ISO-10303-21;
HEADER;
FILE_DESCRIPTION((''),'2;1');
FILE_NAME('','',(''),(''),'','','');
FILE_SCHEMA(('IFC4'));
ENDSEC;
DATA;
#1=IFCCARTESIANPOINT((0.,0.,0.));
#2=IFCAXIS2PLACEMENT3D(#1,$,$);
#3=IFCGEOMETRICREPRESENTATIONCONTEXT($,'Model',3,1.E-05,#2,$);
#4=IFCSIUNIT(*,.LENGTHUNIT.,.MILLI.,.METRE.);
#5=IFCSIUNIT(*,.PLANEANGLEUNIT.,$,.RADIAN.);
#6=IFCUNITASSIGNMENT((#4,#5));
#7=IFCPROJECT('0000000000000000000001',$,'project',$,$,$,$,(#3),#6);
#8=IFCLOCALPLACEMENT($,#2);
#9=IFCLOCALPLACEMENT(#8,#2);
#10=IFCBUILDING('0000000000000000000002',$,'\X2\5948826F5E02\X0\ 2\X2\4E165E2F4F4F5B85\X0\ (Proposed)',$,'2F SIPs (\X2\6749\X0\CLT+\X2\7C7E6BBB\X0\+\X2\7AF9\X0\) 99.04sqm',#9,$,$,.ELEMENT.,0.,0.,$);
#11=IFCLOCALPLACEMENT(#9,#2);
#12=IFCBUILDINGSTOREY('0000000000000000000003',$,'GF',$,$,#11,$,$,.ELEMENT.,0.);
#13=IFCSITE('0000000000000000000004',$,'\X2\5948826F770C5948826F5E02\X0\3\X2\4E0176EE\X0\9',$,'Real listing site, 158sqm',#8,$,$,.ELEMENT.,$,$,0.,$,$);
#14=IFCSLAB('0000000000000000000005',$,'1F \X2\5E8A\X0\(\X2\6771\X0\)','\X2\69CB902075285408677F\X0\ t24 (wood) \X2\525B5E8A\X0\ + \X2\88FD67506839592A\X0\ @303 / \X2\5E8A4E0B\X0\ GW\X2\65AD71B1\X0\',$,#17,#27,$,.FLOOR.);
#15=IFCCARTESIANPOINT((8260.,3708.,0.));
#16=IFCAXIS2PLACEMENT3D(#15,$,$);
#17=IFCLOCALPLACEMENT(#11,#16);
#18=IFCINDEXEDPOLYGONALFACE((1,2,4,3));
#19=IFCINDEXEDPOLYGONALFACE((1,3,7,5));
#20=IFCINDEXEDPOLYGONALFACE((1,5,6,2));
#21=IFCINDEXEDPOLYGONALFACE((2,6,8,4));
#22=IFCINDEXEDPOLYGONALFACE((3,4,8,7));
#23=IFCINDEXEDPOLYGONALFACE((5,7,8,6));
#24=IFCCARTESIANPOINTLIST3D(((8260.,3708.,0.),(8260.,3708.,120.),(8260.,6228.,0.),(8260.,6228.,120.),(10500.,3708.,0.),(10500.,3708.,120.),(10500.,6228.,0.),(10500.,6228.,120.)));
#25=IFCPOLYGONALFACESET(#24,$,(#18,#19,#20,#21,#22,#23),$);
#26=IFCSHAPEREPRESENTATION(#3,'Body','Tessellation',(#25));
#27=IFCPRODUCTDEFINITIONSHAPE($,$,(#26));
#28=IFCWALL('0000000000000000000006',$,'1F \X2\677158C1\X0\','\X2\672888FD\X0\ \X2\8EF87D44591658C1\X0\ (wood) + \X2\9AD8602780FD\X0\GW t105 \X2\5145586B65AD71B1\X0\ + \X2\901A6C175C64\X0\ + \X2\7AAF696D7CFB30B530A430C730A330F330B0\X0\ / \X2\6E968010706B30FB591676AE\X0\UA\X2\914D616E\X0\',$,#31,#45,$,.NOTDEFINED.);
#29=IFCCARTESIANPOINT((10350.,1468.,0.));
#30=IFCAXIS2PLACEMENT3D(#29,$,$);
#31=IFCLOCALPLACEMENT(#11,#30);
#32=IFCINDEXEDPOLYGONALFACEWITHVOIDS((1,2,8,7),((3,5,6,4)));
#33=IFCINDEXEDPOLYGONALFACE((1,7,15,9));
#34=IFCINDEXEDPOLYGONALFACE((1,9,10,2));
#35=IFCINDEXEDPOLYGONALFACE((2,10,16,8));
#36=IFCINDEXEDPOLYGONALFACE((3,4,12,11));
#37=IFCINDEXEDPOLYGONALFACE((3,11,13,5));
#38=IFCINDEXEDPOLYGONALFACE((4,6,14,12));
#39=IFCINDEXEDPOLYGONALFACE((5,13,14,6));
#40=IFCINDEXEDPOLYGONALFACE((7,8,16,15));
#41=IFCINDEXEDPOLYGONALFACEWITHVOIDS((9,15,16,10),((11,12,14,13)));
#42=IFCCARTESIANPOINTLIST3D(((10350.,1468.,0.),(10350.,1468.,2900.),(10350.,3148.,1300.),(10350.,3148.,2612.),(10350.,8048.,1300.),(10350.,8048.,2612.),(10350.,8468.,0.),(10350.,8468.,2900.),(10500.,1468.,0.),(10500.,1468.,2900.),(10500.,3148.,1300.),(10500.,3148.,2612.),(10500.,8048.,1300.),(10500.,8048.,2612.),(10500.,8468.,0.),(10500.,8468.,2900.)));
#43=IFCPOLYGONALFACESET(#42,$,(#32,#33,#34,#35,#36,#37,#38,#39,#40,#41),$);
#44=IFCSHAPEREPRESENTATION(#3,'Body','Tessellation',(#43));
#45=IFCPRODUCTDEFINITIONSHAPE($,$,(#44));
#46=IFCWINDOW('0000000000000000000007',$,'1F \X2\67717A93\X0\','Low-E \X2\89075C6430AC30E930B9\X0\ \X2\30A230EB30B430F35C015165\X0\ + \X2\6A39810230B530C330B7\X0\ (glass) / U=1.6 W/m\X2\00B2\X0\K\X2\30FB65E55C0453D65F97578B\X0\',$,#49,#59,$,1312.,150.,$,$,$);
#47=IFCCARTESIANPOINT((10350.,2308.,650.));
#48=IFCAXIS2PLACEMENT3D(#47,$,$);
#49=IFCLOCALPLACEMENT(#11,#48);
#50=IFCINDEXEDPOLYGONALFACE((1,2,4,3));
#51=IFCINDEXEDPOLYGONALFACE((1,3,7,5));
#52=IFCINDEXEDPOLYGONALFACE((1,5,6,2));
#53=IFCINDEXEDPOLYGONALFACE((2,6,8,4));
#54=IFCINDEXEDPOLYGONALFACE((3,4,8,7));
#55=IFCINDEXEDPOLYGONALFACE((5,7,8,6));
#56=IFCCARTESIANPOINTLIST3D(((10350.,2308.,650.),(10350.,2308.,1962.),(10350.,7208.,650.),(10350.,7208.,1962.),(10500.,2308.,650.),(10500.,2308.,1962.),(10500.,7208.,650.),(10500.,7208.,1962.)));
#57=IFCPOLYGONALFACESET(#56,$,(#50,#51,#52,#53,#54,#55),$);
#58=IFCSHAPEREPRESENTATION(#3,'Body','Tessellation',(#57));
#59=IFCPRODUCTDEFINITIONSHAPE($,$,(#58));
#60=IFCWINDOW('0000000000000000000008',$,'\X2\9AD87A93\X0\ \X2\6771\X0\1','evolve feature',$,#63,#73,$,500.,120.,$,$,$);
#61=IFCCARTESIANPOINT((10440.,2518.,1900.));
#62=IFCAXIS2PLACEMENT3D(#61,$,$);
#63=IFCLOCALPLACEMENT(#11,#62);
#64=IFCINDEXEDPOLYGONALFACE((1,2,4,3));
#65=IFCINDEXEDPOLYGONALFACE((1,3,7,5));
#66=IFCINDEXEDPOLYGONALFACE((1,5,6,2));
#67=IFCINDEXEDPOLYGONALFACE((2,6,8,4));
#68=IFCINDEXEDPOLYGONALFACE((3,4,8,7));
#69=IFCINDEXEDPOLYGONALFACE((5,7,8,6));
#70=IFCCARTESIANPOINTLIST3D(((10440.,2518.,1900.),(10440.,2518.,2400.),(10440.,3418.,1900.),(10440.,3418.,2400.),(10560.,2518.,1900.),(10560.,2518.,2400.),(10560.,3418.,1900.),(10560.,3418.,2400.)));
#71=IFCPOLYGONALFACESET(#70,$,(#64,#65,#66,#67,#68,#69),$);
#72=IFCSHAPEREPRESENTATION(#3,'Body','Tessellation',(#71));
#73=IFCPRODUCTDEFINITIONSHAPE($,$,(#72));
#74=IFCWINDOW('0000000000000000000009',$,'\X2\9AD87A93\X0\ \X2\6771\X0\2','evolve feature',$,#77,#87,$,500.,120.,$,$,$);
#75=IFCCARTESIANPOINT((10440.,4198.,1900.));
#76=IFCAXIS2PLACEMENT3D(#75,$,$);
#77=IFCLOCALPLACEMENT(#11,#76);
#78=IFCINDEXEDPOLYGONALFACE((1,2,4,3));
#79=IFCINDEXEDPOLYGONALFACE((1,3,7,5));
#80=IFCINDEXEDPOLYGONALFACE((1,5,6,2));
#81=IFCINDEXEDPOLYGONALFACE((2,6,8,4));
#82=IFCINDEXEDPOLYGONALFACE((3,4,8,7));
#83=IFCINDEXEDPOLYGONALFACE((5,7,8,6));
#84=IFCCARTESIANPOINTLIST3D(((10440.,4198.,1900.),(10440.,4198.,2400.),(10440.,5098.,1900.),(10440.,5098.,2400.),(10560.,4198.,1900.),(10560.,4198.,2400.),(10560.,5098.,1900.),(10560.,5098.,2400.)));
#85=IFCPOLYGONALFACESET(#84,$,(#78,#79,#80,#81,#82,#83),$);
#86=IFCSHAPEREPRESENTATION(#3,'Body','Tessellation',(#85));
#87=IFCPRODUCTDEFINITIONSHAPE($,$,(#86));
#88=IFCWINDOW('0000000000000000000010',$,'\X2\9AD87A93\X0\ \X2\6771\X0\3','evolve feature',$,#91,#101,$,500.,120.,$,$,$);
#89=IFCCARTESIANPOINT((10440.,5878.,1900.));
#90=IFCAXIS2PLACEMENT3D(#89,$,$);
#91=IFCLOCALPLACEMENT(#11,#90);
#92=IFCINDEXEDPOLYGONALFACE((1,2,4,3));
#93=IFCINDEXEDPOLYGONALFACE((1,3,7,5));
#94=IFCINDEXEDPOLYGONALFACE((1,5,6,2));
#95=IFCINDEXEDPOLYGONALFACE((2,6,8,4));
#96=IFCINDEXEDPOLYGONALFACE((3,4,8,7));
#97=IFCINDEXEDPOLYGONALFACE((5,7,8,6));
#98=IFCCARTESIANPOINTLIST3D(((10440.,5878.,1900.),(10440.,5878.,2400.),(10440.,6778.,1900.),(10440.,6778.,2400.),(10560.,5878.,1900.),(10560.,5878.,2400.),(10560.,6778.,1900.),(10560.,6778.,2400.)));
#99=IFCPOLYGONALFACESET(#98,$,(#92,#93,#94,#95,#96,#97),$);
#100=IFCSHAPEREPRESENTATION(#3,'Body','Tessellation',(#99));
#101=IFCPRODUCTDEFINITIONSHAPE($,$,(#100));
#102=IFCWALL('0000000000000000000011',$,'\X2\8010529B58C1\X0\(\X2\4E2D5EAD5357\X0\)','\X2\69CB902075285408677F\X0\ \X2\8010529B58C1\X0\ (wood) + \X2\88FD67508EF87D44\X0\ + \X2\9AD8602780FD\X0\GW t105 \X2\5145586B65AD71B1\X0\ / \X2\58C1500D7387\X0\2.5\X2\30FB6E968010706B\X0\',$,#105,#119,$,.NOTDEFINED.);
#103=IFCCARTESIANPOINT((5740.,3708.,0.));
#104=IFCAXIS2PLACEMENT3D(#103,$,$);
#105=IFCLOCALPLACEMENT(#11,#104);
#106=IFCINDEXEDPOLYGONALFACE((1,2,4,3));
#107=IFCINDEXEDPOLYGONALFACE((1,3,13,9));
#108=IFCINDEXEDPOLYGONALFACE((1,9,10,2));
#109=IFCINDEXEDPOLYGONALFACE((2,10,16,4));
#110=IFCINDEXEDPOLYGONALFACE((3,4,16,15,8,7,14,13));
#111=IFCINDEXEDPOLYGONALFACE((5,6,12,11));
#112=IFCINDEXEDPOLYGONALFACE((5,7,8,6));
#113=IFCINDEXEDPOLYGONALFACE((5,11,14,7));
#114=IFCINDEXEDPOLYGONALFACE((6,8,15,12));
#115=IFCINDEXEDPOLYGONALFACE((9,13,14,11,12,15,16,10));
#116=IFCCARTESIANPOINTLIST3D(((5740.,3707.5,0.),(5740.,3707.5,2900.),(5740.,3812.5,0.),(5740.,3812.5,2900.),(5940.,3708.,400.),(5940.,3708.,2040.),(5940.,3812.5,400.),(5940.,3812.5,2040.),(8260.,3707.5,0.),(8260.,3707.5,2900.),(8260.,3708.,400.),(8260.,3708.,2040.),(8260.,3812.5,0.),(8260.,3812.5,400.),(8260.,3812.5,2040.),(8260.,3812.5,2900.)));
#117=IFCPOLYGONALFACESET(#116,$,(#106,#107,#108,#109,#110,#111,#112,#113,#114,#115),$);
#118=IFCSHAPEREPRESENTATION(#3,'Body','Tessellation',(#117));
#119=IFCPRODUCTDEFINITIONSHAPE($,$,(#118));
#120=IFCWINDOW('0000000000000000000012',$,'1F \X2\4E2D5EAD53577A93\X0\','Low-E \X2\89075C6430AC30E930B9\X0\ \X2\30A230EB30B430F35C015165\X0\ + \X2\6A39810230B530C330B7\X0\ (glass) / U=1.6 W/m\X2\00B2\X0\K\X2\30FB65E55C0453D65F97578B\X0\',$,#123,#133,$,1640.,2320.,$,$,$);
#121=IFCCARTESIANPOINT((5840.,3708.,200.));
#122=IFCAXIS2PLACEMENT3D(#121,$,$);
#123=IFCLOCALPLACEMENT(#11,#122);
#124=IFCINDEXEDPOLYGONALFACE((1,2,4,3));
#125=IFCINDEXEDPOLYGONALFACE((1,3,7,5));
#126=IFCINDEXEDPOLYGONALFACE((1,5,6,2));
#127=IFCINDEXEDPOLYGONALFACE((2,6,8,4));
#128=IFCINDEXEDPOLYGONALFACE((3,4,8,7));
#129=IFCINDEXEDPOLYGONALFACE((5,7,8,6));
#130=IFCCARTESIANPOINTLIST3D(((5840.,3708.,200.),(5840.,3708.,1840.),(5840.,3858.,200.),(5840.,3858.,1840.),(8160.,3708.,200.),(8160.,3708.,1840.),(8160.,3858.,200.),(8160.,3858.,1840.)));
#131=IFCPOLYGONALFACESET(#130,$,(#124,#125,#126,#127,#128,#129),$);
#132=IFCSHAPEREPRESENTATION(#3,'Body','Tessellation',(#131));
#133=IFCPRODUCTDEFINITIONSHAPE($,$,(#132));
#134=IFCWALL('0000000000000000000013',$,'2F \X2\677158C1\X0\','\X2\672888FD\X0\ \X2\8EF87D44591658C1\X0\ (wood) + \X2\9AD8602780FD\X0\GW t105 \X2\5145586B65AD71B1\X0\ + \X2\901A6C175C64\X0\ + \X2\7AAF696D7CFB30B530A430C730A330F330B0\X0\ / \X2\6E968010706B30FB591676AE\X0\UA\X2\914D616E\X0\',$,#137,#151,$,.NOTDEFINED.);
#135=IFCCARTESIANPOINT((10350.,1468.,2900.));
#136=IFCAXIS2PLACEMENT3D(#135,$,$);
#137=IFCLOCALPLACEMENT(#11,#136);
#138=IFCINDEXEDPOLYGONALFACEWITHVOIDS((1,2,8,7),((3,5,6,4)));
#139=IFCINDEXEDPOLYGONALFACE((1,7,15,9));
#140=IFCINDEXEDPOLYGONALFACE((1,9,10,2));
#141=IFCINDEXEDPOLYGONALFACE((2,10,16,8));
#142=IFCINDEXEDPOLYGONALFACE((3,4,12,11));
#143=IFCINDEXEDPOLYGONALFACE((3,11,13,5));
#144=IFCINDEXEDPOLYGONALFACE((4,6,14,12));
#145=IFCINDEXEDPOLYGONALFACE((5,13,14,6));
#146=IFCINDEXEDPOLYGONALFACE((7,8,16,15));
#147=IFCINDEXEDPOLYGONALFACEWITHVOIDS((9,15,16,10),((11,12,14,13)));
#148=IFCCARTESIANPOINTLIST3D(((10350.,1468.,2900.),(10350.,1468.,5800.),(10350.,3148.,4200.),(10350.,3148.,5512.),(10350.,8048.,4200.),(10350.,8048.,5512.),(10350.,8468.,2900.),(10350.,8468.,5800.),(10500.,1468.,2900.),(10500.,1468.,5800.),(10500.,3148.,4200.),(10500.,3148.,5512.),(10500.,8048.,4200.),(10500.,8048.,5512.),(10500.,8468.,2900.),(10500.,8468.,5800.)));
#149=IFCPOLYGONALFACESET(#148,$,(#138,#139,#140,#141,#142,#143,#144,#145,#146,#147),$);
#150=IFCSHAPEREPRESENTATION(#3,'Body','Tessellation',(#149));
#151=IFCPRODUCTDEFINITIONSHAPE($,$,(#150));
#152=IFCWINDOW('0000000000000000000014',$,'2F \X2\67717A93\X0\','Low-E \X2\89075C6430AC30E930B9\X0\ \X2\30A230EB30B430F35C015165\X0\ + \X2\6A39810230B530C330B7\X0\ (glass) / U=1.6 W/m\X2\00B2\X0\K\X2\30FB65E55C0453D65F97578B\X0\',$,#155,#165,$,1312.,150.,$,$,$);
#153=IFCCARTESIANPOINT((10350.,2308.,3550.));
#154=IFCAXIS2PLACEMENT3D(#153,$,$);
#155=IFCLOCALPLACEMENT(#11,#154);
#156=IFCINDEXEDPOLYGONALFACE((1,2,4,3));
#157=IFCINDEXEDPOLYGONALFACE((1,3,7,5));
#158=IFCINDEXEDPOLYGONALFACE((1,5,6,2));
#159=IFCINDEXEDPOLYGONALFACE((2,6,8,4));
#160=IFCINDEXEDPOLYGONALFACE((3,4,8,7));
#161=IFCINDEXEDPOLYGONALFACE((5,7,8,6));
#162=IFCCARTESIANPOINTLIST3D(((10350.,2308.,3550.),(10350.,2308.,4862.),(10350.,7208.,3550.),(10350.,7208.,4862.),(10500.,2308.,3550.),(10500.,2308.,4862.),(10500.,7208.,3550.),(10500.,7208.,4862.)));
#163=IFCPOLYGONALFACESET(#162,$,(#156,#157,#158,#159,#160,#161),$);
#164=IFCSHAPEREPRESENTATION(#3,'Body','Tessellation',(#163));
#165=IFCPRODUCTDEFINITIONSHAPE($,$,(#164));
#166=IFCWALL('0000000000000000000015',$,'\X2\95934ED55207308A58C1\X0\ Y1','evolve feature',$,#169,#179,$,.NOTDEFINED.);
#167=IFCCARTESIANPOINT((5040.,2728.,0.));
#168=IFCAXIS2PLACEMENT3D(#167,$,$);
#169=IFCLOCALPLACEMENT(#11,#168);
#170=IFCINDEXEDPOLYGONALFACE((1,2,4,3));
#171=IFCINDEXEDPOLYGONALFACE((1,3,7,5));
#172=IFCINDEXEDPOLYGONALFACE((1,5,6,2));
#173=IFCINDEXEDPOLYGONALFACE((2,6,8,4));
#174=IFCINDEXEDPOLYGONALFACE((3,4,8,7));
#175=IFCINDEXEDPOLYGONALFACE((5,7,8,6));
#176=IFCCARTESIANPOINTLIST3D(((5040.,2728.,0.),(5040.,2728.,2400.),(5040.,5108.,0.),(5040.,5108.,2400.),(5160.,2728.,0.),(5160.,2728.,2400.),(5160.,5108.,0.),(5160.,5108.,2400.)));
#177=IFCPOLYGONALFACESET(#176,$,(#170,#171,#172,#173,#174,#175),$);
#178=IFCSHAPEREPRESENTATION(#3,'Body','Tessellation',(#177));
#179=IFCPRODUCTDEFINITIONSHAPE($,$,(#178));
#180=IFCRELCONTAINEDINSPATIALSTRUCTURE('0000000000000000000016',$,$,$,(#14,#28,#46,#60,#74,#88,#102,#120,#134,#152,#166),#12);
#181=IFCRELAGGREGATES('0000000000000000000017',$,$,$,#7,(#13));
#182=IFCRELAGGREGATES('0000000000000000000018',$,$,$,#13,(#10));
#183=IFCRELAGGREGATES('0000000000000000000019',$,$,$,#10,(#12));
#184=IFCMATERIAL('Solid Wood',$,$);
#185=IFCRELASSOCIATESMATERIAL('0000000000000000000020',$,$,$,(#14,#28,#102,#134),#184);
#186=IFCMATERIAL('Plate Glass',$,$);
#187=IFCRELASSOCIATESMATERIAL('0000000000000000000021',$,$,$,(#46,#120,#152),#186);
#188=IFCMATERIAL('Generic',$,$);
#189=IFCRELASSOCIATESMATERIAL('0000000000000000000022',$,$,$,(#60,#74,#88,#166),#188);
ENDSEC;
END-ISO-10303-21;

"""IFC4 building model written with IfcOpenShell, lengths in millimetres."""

from ifc_helpers import new_model, si_unit, frame, frame_2d, origin, place, context, project, spatial, rectangle, extrude, material, element, fill, save


model = new_model("IFC4")

# Units and contexts
model_context = context("Model", 3, precision=1e-05, world=origin())
ifc_project = project(units=[si_unit("LENGTHUNIT", "METRE", prefix="MILLI"), si_unit("PLANEANGLEUNIT", "RADIAN")], contexts=[model_context])

# Site, building, storey
site_placement = place(None, origin())
site = spatial("IfcSite", under=ifc_project, at=site_placement, Name="奈良県奈良市3丁目9", ObjectType="Real listing site, 158sqm", CompositionType="ELEMENT", RefElevation=0.0)
building_placement = place(site_placement, origin())
building = spatial("IfcBuilding", under=site, at=building_placement, Name="奈良市 2世帯住宅 (Proposed)", ObjectType="2F SIPs (杉CLT+籾殻+竹) 99.04sqm", CompositionType="ELEMENT", ElevationOfRefHeight=0.0, ElevationOfTerrain=0.0)
storey_placement = place(building_placement, origin())
storey = spatial("IfcBuildingStorey", under=building, at=storey_placement, Name="GF", CompositionType="ELEMENT", Elevation=0.0)

# Slab
ifc_material_1 = material(Name="Solid Wood")
slab_placement = place(storey_placement, frame((8260.0, 3708.0, 0.0)))
element("IfcSlab", 1, at=slab_placement, inside=storey, material=ifc_material_1, Name="1F 床(東)", Description="構造用合板 t24 (wood) 剛床 + 製材根太 @303 / 床下 GW断熱", PredefinedType="FLOOR", context=model_context, shape_type="SweptSolid", body=[
    extrude(rectangle(XDim=2240.0, YDim=2520.0, at=frame_2d((1120.0, 1260.0))), frame((8260.0, 3708.0, 0.0)), (0.0, 0.0, 1.0), 120.0),
])

# Wall, openings, windows
wall_1_placement = place(storey_placement, frame((10350.0, 1468.0, 0.0)))
wall_1 = element("IfcWall", 2, at=wall_1_placement, inside=storey, material=ifc_material_1, Name="1F 東壁", Description="木製 軸組外壁 (wood) + 高性能GW t105 充填断熱 + 通気層 + 窯業系サイディング / 準耐火・外皮UA配慮", PredefinedType="NOTDEFINED", context=model_context, shape_type="SweptSolid", body=[
    extrude(rectangle(XDim=150.0, YDim=7000.0, at=frame_2d((75.0, 3500.0))), frame((10350.0, 1468.0, 0.0)), (0.0, 0.0, 1.0), 2900.0),
])
opening_1_placement = place(storey_placement, frame((10350.0, 2308.0, 650.0)))
opening_1 = element("IfcOpeningElement", 3, at=opening_1_placement, cuts=wall_1, PredefinedType="NOTDEFINED", context=model_context, shape_type="SweptSolid", body=[
    extrude(rectangle(XDim=150.0, YDim=4900.0, at=frame_2d((75.0, 2450.0))), frame((10350.0, 2308.0, 650.0)), (0.0, 0.0, 1.0), 1312.0),
])
opening_2_placement = place(storey_placement, frame((10440.0, 2518.0, 1900.0)))
opening_2 = element("IfcOpeningElement", 4, at=opening_2_placement, cuts=wall_1, PredefinedType="NOTDEFINED", context=model_context, shape_type="SweptSolid", body=[
    extrude(rectangle(XDim=120.0, YDim=900.0, at=frame_2d((60.0, 450.0))), frame((10440.0, 2518.0, 1900.0)), (0.0, 0.0, 1.0), 500.0),
])
opening_3_placement = place(storey_placement, frame((10440.0, 4198.0, 1900.0)))
opening_3 = element("IfcOpeningElement", 5, at=opening_3_placement, cuts=wall_1, PredefinedType="NOTDEFINED", context=model_context, shape_type="SweptSolid", body=[
    extrude(rectangle(XDim=120.0, YDim=900.0, at=frame_2d((60.0, 450.0))), frame((10440.0, 4198.0, 1900.0)), (0.0, 0.0, 1.0), 500.0),
])
opening_4_placement = place(storey_placement, frame((10440.0, 5878.0, 1900.0)))
opening_4 = element("IfcOpeningElement", 6, at=opening_4_placement, cuts=wall_1, PredefinedType="NOTDEFINED", context=model_context, shape_type="SweptSolid", body=[
    extrude(rectangle(XDim=120.0, YDim=900.0, at=frame_2d((60.0, 450.0))), frame((10440.0, 5878.0, 1900.0)), (0.0, 0.0, 1.0), 500.0),
])
ifc_material_2 = material(Name="Plate Glass")
window_1_placement = place(storey_placement, frame((10350.0, 2308.0, 650.0)))
window_1 = element("IfcWindow", 7, at=window_1_placement, inside=storey, material=ifc_material_2, Name="1F 東窓", Description="Low-E 複層ガラス アルゴン封入 + 樹脂サッシ (glass) / U=1.6 W/m²K・日射取得型", OverallHeight=1312.0, OverallWidth=150.0, context=model_context, shape_type="SweptSolid", body=[
    extrude(rectangle(XDim=150.0, YDim=4900.0, at=frame_2d((75.0, 2450.0))), frame((10350.0, 2308.0, 650.0)), (0.0, 0.0, 1.0), 1312.0),
])
fill(opening_1, window_1)
ifc_material_3 = material(Name="Generic")
window_2_placement = place(storey_placement, frame((10440.0, 2518.0, 1900.0)))
window_2 = element("IfcWindow", 8, at=window_2_placement, inside=storey, material=ifc_material_3, Name="高窓 東1", Description="evolve feature", OverallHeight=500.0, OverallWidth=120.0, context=model_context, shape_type="SweptSolid", body=[
    extrude(rectangle(XDim=120.0, YDim=900.0, at=frame_2d((60.0, 450.0))), frame((10440.0, 2518.0, 1900.0)), (0.0, 0.0, 1.0), 500.0),
])
fill(opening_2, window_2)
window_3_placement = place(storey_placement, frame((10440.0, 4198.0, 1900.0)))
window_3 = element("IfcWindow", 9, at=window_3_placement, inside=storey, material=ifc_material_3, Name="高窓 東2", Description="evolve feature", OverallHeight=500.0, OverallWidth=120.0, context=model_context, shape_type="SweptSolid", body=[
    extrude(rectangle(XDim=120.0, YDim=900.0, at=frame_2d((60.0, 450.0))), frame((10440.0, 4198.0, 1900.0)), (0.0, 0.0, 1.0), 500.0),
])
fill(opening_3, window_3)
window_4_placement = place(storey_placement, frame((10440.0, 5878.0, 1900.0)))
window_4 = element("IfcWindow", 10, at=window_4_placement, inside=storey, material=ifc_material_3, Name="高窓 東3", Description="evolve feature", OverallHeight=500.0, OverallWidth=120.0, context=model_context, shape_type="SweptSolid", body=[
    extrude(rectangle(XDim=120.0, YDim=900.0, at=frame_2d((60.0, 450.0))), frame((10440.0, 5878.0, 1900.0)), (0.0, 0.0, 1.0), 500.0),
])
fill(opening_4, window_4)

# Wall, opening, window
wall_2_placement = place(storey_placement, frame((5740.0, 3708.0, 0.0)))
wall_2 = element("IfcWall", 11, at=wall_2_placement, inside=storey, material=ifc_material_1, Name="耐力壁(中庭南)", Description="構造用合板 耐力壁 (wood) + 製材軸組 + 高性能GW t105 充填断熱 / 壁倍率2.5・準耐火", PredefinedType="NOTDEFINED", context=model_context, shape_type="SweptSolid", body=[
    extrude(rectangle(XDim=2520.0, YDim=105.0, at=frame_2d((1260.0, 52.0))), frame((5740.0, 3708.0, 0.0)), (0.0, 0.0, 1.0), 2900.0),
])
opening_5_placement = place(storey_placement, frame((5840.0, 3708.0, 200.0)))
opening_5 = element("IfcOpeningElement", 12, at=opening_5_placement, cuts=wall_2, PredefinedType="NOTDEFINED", context=model_context, shape_type="SweptSolid", body=[
    extrude(rectangle(XDim=2320.0, YDim=150.0, at=frame_2d((1160.0, 75.0))), frame((5840.0, 3708.0, 200.0)), (0.0, 0.0, 1.0), 1640.0),
])
window_5_placement = place(storey_placement, frame((5840.0, 3708.0, 200.0)))
window_5 = element("IfcWindow", 13, at=window_5_placement, inside=storey, material=ifc_material_2, Name="1F 中庭南窓", Description="Low-E 複層ガラス アルゴン封入 + 樹脂サッシ (glass) / U=1.6 W/m²K・日射取得型", OverallHeight=1640.0, OverallWidth=2320.0, context=model_context, shape_type="SweptSolid", body=[
    extrude(rectangle(XDim=2320.0, YDim=150.0, at=frame_2d((1160.0, 75.0))), frame((5840.0, 3708.0, 200.0)), (0.0, 0.0, 1.0), 1640.0),
])
fill(opening_5, window_5)

# Wall, opening, window
wall_3_placement = place(storey_placement, frame((10350.0, 1468.0, 2900.0)))
wall_3 = element("IfcWall", 14, at=wall_3_placement, inside=storey, material=ifc_material_1, Name="2F 東壁", Description="木製 軸組外壁 (wood) + 高性能GW t105 充填断熱 + 通気層 + 窯業系サイディング / 準耐火・外皮UA配慮", PredefinedType="NOTDEFINED", context=model_context, shape_type="SweptSolid", body=[
    extrude(rectangle(XDim=150.0, YDim=7000.0, at=frame_2d((75.0, 3500.0))), frame((10350.0, 1468.0, 2900.0)), (0.0, 0.0, 1.0), 2900.0),
])
opening_6_placement = place(storey_placement, frame((10350.0, 2308.0, 3550.0)))
opening_6 = element("IfcOpeningElement", 15, at=opening_6_placement, cuts=wall_3, PredefinedType="NOTDEFINED", context=model_context, shape_type="SweptSolid", body=[
    extrude(rectangle(XDim=150.0, YDim=4900.0, at=frame_2d((75.0, 2450.0))), frame((10350.0, 2308.0, 3550.0)), (0.0, 0.0, 1.0), 1312.0),
])
window_6_placement = place(storey_placement, frame((10350.0, 2308.0, 3550.0)))
window_6 = element("IfcWindow", 16, at=window_6_placement, inside=storey, material=ifc_material_2, Name="2F 東窓", Description="Low-E 複層ガラス アルゴン封入 + 樹脂サッシ (glass) / U=1.6 W/m²K・日射取得型", OverallHeight=1312.0, OverallWidth=150.0, context=model_context, shape_type="SweptSolid", body=[
    extrude(rectangle(XDim=150.0, YDim=4900.0, at=frame_2d((75.0, 2450.0))), frame((10350.0, 2308.0, 3550.0)), (0.0, 0.0, 1.0), 1312.0),
])
fill(opening_6, window_6)

# Wall
wall_4_placement = place(storey_placement, frame((5040.0, 2728.0, 0.0)))
element("IfcWall", 17, at=wall_4_placement, inside=storey, material=ifc_material_3, Name="間仕切り壁 Y1", Description="evolve feature", PredefinedType="NOTDEFINED", context=model_context, shape_type="SweptSolid", body=[
    extrude(rectangle(XDim=120.0, YDim=2380.0, at=frame_2d((60.0, 1190.0))), frame((5040.0, 2728.0, 0.0)), (0.0, 0.0, 1.0), 2400.0),
])

save(model, "model.ifc")
